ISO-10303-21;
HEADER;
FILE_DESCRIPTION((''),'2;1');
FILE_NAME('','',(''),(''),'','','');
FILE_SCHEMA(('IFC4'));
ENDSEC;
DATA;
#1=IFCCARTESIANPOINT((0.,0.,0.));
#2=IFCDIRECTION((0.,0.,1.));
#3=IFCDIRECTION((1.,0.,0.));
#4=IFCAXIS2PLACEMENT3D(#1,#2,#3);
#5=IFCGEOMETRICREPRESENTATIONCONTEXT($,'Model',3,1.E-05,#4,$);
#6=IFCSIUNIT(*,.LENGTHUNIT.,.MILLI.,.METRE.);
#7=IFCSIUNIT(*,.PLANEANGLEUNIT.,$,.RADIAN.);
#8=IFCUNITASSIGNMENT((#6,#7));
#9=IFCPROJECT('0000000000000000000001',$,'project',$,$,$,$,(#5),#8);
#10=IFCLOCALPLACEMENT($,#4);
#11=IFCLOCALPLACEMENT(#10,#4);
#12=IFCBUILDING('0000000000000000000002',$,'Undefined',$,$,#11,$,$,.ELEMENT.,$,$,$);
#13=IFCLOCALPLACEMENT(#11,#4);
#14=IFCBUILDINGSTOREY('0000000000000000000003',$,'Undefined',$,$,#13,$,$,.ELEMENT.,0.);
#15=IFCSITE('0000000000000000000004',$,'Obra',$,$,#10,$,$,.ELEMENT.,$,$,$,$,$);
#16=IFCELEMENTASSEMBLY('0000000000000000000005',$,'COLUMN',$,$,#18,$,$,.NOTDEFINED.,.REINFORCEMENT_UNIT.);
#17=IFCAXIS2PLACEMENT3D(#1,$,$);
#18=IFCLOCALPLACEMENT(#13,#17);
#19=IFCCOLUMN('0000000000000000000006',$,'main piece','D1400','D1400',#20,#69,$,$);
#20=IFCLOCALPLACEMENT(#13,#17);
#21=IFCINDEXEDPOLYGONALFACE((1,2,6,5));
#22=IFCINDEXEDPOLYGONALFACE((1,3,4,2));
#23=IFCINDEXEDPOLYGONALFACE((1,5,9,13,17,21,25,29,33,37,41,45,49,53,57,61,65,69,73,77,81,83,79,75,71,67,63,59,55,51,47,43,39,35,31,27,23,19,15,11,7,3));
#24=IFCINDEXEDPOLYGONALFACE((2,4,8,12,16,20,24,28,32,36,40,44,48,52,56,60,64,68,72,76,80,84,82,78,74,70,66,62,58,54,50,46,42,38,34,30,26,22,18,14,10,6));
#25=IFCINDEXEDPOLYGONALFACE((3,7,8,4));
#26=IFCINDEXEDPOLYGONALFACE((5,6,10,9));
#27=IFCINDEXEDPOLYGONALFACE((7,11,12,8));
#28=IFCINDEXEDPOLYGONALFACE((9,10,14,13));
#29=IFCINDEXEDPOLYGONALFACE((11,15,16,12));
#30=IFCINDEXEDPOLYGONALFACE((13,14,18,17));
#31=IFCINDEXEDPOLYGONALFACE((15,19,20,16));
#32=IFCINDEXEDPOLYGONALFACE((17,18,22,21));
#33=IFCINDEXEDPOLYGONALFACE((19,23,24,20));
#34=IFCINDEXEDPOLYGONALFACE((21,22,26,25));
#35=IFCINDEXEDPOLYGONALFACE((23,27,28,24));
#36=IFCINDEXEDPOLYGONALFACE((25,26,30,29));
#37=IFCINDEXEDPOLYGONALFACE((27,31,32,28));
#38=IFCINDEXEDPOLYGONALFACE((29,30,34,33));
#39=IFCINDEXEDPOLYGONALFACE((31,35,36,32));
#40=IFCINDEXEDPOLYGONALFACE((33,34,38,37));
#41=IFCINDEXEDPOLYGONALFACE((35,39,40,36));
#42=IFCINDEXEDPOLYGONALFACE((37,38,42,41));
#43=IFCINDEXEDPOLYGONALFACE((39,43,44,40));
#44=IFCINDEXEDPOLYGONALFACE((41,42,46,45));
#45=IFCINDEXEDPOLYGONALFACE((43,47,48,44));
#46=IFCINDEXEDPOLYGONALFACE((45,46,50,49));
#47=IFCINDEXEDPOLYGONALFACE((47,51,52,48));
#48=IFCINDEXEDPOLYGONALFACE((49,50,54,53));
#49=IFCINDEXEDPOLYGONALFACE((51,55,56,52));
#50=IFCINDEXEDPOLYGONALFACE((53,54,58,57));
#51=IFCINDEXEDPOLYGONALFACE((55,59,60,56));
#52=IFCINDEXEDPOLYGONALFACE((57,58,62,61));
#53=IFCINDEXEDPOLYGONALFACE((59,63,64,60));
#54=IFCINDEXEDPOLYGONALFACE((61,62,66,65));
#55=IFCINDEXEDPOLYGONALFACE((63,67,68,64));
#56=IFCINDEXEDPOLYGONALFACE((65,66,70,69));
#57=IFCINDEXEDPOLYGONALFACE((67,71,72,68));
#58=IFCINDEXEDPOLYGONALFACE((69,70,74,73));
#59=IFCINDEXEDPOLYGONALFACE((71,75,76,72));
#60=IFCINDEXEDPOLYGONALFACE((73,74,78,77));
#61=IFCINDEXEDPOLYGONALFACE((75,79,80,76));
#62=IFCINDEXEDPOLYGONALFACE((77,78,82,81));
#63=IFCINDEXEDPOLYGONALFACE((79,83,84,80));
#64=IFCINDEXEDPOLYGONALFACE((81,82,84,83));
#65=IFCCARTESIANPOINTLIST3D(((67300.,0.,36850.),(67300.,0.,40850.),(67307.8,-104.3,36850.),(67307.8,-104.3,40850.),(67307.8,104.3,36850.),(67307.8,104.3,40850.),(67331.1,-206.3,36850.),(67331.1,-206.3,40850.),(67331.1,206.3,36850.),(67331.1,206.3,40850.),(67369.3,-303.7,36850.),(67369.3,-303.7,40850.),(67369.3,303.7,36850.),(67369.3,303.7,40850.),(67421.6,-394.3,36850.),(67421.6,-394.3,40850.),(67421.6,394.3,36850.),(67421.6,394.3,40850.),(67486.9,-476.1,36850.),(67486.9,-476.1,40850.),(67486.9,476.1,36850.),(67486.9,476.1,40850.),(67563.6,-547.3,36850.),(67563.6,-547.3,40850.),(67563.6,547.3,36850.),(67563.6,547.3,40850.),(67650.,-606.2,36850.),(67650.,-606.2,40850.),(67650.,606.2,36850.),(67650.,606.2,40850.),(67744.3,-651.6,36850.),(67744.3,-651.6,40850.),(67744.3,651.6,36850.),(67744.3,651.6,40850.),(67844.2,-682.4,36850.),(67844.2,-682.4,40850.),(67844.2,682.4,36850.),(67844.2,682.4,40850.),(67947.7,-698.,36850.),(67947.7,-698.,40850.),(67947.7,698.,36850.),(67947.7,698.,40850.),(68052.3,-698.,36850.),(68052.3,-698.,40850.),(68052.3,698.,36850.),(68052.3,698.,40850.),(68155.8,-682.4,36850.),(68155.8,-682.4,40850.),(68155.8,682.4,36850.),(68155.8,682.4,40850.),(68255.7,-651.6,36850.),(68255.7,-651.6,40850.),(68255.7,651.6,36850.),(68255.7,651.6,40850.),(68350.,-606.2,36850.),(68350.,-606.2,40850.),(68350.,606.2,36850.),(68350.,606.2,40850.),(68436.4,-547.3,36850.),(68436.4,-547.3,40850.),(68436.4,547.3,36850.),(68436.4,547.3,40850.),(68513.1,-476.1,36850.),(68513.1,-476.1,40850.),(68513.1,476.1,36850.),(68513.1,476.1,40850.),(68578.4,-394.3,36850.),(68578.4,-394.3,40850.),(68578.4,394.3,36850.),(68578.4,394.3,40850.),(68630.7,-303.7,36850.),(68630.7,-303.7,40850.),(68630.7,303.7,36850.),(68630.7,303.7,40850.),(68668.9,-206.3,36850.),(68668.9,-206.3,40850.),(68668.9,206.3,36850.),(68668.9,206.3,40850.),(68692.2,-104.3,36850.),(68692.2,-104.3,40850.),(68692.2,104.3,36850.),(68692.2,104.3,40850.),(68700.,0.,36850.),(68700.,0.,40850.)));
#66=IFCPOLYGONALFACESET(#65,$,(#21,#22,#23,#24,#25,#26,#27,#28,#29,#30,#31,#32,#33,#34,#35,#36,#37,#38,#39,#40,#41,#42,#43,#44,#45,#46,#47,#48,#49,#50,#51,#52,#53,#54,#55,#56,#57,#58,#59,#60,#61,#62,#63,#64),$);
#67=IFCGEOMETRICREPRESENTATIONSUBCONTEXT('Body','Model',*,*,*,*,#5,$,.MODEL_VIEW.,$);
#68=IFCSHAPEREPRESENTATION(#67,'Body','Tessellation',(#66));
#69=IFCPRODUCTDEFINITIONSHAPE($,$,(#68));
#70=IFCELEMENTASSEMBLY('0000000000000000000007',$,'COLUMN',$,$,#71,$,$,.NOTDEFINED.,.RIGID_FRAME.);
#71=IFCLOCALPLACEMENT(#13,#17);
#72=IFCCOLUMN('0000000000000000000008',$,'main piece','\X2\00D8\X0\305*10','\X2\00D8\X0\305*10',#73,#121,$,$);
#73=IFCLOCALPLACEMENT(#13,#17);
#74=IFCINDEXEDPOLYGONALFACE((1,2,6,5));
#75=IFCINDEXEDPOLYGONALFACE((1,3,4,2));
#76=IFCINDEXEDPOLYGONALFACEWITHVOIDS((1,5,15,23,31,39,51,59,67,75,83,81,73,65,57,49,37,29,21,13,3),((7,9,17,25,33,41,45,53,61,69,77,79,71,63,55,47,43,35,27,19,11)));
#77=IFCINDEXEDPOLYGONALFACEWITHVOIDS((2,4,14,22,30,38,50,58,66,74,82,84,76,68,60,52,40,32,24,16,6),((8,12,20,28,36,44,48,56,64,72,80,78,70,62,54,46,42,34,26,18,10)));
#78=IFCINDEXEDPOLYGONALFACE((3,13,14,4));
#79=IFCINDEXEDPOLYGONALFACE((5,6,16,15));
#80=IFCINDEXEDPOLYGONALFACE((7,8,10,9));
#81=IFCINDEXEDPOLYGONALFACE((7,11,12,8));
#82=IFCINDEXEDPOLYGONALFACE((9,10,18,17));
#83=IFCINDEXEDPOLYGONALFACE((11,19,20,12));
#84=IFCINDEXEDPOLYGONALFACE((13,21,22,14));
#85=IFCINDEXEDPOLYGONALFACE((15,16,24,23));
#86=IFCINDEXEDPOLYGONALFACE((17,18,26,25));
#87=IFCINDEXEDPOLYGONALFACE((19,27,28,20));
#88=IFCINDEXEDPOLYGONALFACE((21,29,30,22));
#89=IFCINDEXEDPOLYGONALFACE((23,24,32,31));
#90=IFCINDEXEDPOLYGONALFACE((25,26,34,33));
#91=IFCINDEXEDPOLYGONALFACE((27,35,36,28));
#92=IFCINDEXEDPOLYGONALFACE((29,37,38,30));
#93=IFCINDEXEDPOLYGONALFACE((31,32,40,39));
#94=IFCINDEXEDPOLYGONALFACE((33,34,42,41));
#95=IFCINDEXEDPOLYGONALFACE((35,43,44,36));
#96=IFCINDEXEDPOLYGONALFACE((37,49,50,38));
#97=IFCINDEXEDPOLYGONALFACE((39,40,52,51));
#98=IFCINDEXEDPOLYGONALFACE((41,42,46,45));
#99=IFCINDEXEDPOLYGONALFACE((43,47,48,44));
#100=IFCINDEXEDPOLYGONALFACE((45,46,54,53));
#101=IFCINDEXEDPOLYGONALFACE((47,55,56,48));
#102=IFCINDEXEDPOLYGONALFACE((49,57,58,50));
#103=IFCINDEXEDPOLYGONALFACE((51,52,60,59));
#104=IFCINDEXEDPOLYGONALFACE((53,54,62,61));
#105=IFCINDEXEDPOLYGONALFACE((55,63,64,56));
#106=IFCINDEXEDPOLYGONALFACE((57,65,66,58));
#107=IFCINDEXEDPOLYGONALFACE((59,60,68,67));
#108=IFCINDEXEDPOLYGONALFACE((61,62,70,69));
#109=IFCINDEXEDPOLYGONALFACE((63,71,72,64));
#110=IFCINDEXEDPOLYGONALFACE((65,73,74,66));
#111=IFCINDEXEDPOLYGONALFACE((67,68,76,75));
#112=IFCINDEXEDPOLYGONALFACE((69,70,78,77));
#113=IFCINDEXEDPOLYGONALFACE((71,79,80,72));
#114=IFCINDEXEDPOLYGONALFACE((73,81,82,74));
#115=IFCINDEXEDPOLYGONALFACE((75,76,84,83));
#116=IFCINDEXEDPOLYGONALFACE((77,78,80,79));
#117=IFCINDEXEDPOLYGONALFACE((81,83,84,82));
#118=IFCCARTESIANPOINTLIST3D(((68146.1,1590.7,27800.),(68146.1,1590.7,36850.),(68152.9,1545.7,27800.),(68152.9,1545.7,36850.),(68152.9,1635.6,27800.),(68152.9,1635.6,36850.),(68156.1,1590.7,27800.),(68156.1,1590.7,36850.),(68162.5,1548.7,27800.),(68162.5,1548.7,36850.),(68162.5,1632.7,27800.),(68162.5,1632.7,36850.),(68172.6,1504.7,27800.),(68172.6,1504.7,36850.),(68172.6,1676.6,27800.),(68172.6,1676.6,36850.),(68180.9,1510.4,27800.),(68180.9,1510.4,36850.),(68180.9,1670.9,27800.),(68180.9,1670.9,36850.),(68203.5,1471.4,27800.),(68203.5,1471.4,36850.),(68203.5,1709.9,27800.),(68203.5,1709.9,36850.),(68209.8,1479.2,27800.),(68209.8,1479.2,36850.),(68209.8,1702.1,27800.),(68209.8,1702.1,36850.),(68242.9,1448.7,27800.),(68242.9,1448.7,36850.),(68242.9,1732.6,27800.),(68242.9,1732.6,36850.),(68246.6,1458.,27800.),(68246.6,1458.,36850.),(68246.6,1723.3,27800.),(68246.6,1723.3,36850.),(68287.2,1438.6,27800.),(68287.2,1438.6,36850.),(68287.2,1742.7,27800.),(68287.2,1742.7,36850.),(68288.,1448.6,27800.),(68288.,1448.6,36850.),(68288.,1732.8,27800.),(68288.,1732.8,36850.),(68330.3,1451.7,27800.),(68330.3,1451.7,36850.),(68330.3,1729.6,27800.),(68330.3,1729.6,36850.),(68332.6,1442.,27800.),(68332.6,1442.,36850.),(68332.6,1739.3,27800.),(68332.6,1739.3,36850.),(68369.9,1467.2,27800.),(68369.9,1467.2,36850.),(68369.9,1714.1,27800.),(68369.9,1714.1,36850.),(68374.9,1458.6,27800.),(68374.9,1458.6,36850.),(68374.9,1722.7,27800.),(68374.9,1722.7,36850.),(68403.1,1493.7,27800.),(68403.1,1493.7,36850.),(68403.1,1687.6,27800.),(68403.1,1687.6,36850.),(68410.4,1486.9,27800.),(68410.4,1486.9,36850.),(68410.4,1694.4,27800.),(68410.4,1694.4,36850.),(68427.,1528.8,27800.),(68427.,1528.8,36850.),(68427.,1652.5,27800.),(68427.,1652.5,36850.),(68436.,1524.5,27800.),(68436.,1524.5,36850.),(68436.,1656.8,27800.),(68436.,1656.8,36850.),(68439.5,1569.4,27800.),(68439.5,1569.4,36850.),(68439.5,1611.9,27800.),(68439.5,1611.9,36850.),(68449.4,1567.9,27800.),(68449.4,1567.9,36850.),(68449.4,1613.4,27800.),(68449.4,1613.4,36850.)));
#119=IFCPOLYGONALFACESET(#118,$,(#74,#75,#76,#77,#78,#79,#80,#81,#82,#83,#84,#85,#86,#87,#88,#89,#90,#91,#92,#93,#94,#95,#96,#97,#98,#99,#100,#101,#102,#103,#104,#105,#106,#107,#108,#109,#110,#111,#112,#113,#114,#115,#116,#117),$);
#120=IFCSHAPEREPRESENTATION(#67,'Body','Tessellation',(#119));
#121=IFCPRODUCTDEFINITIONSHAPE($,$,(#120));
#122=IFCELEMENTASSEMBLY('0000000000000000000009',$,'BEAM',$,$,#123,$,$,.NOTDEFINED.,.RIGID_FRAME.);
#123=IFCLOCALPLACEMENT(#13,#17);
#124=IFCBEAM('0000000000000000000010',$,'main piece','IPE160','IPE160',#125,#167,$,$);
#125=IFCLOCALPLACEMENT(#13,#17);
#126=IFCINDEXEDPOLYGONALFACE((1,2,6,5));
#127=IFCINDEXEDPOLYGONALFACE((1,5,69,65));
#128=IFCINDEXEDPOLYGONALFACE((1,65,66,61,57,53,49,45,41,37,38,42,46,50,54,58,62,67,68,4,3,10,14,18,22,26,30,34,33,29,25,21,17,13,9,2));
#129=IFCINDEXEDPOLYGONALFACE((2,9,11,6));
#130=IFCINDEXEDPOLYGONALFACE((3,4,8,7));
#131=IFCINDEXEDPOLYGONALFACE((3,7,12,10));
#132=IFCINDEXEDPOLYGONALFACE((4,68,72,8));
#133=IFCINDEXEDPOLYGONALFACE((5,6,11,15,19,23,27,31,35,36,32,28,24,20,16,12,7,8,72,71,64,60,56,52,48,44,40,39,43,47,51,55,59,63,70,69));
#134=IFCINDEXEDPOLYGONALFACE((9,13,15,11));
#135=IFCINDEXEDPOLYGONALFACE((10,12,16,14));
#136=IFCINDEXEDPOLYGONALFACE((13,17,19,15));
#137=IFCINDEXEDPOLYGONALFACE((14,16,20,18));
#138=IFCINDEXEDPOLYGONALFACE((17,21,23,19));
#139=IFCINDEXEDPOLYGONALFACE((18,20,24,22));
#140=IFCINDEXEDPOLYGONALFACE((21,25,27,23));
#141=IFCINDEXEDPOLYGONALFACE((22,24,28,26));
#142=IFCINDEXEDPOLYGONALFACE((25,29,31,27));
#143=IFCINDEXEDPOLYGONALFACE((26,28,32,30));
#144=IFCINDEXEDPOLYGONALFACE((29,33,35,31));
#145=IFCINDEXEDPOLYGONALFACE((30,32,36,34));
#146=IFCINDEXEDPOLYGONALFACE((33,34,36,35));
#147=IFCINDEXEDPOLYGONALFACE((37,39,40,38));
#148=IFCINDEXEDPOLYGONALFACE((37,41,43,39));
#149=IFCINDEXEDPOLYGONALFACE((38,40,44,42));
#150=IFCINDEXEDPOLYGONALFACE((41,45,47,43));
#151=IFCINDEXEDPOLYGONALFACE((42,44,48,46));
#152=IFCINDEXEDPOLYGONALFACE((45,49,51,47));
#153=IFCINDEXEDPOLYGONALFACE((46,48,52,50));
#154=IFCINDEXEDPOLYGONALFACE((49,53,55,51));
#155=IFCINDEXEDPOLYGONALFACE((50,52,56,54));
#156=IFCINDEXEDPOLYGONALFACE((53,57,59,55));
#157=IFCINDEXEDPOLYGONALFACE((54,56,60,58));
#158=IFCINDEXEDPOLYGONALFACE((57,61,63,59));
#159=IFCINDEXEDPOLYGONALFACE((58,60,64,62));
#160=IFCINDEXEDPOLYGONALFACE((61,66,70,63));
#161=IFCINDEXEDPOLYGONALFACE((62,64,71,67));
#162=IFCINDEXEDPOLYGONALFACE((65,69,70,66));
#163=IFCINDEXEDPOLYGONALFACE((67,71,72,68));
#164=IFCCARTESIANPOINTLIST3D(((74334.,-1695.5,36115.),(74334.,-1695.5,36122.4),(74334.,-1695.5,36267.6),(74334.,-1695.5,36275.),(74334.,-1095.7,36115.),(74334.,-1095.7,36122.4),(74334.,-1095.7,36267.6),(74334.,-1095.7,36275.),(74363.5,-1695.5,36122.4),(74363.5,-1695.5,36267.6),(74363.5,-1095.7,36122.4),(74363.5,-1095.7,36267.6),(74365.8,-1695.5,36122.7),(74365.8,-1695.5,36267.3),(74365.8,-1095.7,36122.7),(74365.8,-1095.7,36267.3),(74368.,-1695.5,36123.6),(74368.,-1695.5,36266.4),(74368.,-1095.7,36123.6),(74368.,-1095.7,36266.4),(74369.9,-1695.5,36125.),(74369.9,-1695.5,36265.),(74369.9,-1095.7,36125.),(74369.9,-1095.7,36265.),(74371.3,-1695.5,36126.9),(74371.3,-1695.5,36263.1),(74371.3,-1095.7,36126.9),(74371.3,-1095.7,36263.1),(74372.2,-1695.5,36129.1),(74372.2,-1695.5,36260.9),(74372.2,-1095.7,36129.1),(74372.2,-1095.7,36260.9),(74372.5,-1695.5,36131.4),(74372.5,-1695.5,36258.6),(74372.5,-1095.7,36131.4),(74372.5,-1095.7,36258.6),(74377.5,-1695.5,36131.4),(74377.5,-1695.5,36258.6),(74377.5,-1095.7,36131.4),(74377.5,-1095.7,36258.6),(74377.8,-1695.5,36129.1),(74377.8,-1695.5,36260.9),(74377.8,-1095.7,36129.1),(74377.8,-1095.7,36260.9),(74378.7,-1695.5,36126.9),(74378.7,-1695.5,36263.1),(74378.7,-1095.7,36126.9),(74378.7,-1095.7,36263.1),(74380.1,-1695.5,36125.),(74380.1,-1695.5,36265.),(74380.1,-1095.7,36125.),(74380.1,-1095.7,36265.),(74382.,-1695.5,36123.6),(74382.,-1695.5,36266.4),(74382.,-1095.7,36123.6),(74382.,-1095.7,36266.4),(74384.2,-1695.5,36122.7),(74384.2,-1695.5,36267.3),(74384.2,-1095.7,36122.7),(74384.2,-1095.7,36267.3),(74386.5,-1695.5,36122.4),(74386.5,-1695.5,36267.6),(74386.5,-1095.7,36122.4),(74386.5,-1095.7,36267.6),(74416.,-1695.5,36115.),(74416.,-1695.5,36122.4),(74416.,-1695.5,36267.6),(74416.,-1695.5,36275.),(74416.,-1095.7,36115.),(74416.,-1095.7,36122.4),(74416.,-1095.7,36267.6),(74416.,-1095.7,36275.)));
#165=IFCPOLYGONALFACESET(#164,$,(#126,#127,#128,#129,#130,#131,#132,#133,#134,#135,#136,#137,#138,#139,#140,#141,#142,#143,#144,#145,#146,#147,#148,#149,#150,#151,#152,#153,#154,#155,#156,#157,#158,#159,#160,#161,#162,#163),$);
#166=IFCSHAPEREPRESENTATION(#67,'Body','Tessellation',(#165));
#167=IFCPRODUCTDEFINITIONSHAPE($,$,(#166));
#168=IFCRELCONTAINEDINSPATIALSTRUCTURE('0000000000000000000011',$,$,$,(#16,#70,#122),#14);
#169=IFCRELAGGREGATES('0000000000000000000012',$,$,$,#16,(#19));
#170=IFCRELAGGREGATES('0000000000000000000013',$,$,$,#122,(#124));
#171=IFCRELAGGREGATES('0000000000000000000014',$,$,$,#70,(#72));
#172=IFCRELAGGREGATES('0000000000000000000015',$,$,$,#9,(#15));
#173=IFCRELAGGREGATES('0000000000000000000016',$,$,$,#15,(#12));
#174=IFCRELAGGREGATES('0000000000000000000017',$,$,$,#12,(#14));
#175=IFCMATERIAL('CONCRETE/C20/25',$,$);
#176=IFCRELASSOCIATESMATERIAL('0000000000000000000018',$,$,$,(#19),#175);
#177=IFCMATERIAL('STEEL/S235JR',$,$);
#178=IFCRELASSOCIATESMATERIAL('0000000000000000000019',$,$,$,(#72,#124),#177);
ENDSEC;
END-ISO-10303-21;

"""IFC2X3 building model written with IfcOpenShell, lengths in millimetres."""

from ifc_helpers import new_model, si_unit, frame, origin_with_axes, origin_2d_with_axis, place, context, subcontext, project, spatial, circle, hollow_circle, i_section, extrude, material, element, aggregate, save


model = new_model("IFC2X3")

# Units and contexts
model_context = context("Model", 3, precision=1e-05, world=origin_with_axes())
body_context = subcontext(model_context, "Body", "Model", "MODEL_VIEW")
ifc_project = project(units=[si_unit("LENGTHUNIT", "METRE", prefix="MILLI"), si_unit("PLANEANGLEUNIT", "RADIAN")], contexts=[model_context])

# Site, building, storey
site_placement = place(None, origin_with_axes())
site = spatial("IfcSite", under=ifc_project, at=site_placement, Name="Obra", CompositionType="ELEMENT")
building_placement = place(site_placement, origin_with_axes())
building = spatial("IfcBuilding", under=site, at=building_placement, Name="Undefined", CompositionType="ELEMENT")
storey_placement = place(building_placement, origin_with_axes())
storey = spatial("IfcBuildingStorey", under=building, at=storey_placement, Name="Undefined", CompositionType="ELEMENT", Elevation=0.0)

# Element assemblies, columns
assembly_1_placement = place(storey_placement, origin_with_axes())
assembly_1 = element("IfcElementAssembly", 1, at=assembly_1_placement, inside=storey, Name="COLUMN", AssemblyPlace="NOTDEFINED", PredefinedType="REINFORCEMENT_UNIT")
ifc_material_1 = material(Name="CONCRETE/C20/25")
column_1_placement = place(assembly_1_placement, frame((68000.0, 0.0, 36850.0), z_axis=(0.0, 0.0, 1.0), x_axis=(0.0, 1.0, 0.0)))
column_1 = element("IfcColumn", 2, at=column_1_placement, material=ifc_material_1, Name="main piece", Description="D1400", ObjectType="D1400", context=body_context, shape_type="SweptSolid", body=[
    extrude(circle(Radius=700.0, at=origin_2d_with_axis()), frame((0.0, 0.0, 4000.0), z_axis=(0.0, 0.0, -1.0), x_axis=(0.0, 1.0, 0.0)), (0.0, 0.0, 1.0), 4000.0),
])
aggregate(assembly_1, [column_1])
assembly_2_placement = place(storey_placement, origin_with_axes())
assembly_2 = element("IfcElementAssembly", 3, at=assembly_2_placement, inside=storey, Name="COLUMN", AssemblyPlace="NOTDEFINED", PredefinedType="RIGID_FRAME")
ifc_material_2 = material(Name="STEEL/S235JR")
column_2_placement = place(assembly_2_placement, frame((68298.6, 1590.7, 27800.0), z_axis=(0.0, 0.0, 1.0), x_axis=(0.0, 1.0, 0.0)))
column_2 = element("IfcColumn", 4, at=column_2_placement, material=ifc_material_2, Name="main piece", Description="Ø305*10", ObjectType="Ø305*10", context=body_context, shape_type="SweptSolid", body=[
    extrude(hollow_circle(Radius=152.5, WallThickness=10.0, at=origin_2d_with_axis()), frame((0.0, 0.0, 9050.0), z_axis=(0.0, 0.0, -1.0), x_axis=(0.0, 1.0, 0.0)), (0.0, 0.0, 1.0), 9050.0),
])

# Element assembly, beam
assembly_3_placement = place(storey_placement, origin_with_axes())
assembly_3 = element("IfcElementAssembly", 5, at=assembly_3_placement, inside=storey, Name="BEAM", AssemblyPlace="NOTDEFINED", PredefinedType="RIGID_FRAME")
beam_1_placement = place(assembly_3_placement, frame((74375.0, -1095.7, 36195.0), z_axis=(0.0, 0.0, 1.0), x_axis=(0.0, -1.0, 0.0)))
beam_1 = element("IfcBeam", 6, at=beam_1_placement, material=ifc_material_2, Name="main piece", Description="IPE160", ObjectType="IPE160", context=body_context, shape_type="SweptSolid", body=[
    extrude(i_section(OverallWidth=82.0, OverallDepth=160.0, WebThickness=5.0, FlangeThickness=7.4, FilletRadius=9.0, at=origin_2d_with_axis()), frame((599.8, 0.0, 0.0), z_axis=(-1.0, 0.0, 0.0), x_axis=(0.0, -1.0, 0.0)), (0.0, 0.0, 1.0), 599.8),
])
aggregate(assembly_3, [beam_1])

aggregate(assembly_2, [column_2])

save(model, "model.ifc")
